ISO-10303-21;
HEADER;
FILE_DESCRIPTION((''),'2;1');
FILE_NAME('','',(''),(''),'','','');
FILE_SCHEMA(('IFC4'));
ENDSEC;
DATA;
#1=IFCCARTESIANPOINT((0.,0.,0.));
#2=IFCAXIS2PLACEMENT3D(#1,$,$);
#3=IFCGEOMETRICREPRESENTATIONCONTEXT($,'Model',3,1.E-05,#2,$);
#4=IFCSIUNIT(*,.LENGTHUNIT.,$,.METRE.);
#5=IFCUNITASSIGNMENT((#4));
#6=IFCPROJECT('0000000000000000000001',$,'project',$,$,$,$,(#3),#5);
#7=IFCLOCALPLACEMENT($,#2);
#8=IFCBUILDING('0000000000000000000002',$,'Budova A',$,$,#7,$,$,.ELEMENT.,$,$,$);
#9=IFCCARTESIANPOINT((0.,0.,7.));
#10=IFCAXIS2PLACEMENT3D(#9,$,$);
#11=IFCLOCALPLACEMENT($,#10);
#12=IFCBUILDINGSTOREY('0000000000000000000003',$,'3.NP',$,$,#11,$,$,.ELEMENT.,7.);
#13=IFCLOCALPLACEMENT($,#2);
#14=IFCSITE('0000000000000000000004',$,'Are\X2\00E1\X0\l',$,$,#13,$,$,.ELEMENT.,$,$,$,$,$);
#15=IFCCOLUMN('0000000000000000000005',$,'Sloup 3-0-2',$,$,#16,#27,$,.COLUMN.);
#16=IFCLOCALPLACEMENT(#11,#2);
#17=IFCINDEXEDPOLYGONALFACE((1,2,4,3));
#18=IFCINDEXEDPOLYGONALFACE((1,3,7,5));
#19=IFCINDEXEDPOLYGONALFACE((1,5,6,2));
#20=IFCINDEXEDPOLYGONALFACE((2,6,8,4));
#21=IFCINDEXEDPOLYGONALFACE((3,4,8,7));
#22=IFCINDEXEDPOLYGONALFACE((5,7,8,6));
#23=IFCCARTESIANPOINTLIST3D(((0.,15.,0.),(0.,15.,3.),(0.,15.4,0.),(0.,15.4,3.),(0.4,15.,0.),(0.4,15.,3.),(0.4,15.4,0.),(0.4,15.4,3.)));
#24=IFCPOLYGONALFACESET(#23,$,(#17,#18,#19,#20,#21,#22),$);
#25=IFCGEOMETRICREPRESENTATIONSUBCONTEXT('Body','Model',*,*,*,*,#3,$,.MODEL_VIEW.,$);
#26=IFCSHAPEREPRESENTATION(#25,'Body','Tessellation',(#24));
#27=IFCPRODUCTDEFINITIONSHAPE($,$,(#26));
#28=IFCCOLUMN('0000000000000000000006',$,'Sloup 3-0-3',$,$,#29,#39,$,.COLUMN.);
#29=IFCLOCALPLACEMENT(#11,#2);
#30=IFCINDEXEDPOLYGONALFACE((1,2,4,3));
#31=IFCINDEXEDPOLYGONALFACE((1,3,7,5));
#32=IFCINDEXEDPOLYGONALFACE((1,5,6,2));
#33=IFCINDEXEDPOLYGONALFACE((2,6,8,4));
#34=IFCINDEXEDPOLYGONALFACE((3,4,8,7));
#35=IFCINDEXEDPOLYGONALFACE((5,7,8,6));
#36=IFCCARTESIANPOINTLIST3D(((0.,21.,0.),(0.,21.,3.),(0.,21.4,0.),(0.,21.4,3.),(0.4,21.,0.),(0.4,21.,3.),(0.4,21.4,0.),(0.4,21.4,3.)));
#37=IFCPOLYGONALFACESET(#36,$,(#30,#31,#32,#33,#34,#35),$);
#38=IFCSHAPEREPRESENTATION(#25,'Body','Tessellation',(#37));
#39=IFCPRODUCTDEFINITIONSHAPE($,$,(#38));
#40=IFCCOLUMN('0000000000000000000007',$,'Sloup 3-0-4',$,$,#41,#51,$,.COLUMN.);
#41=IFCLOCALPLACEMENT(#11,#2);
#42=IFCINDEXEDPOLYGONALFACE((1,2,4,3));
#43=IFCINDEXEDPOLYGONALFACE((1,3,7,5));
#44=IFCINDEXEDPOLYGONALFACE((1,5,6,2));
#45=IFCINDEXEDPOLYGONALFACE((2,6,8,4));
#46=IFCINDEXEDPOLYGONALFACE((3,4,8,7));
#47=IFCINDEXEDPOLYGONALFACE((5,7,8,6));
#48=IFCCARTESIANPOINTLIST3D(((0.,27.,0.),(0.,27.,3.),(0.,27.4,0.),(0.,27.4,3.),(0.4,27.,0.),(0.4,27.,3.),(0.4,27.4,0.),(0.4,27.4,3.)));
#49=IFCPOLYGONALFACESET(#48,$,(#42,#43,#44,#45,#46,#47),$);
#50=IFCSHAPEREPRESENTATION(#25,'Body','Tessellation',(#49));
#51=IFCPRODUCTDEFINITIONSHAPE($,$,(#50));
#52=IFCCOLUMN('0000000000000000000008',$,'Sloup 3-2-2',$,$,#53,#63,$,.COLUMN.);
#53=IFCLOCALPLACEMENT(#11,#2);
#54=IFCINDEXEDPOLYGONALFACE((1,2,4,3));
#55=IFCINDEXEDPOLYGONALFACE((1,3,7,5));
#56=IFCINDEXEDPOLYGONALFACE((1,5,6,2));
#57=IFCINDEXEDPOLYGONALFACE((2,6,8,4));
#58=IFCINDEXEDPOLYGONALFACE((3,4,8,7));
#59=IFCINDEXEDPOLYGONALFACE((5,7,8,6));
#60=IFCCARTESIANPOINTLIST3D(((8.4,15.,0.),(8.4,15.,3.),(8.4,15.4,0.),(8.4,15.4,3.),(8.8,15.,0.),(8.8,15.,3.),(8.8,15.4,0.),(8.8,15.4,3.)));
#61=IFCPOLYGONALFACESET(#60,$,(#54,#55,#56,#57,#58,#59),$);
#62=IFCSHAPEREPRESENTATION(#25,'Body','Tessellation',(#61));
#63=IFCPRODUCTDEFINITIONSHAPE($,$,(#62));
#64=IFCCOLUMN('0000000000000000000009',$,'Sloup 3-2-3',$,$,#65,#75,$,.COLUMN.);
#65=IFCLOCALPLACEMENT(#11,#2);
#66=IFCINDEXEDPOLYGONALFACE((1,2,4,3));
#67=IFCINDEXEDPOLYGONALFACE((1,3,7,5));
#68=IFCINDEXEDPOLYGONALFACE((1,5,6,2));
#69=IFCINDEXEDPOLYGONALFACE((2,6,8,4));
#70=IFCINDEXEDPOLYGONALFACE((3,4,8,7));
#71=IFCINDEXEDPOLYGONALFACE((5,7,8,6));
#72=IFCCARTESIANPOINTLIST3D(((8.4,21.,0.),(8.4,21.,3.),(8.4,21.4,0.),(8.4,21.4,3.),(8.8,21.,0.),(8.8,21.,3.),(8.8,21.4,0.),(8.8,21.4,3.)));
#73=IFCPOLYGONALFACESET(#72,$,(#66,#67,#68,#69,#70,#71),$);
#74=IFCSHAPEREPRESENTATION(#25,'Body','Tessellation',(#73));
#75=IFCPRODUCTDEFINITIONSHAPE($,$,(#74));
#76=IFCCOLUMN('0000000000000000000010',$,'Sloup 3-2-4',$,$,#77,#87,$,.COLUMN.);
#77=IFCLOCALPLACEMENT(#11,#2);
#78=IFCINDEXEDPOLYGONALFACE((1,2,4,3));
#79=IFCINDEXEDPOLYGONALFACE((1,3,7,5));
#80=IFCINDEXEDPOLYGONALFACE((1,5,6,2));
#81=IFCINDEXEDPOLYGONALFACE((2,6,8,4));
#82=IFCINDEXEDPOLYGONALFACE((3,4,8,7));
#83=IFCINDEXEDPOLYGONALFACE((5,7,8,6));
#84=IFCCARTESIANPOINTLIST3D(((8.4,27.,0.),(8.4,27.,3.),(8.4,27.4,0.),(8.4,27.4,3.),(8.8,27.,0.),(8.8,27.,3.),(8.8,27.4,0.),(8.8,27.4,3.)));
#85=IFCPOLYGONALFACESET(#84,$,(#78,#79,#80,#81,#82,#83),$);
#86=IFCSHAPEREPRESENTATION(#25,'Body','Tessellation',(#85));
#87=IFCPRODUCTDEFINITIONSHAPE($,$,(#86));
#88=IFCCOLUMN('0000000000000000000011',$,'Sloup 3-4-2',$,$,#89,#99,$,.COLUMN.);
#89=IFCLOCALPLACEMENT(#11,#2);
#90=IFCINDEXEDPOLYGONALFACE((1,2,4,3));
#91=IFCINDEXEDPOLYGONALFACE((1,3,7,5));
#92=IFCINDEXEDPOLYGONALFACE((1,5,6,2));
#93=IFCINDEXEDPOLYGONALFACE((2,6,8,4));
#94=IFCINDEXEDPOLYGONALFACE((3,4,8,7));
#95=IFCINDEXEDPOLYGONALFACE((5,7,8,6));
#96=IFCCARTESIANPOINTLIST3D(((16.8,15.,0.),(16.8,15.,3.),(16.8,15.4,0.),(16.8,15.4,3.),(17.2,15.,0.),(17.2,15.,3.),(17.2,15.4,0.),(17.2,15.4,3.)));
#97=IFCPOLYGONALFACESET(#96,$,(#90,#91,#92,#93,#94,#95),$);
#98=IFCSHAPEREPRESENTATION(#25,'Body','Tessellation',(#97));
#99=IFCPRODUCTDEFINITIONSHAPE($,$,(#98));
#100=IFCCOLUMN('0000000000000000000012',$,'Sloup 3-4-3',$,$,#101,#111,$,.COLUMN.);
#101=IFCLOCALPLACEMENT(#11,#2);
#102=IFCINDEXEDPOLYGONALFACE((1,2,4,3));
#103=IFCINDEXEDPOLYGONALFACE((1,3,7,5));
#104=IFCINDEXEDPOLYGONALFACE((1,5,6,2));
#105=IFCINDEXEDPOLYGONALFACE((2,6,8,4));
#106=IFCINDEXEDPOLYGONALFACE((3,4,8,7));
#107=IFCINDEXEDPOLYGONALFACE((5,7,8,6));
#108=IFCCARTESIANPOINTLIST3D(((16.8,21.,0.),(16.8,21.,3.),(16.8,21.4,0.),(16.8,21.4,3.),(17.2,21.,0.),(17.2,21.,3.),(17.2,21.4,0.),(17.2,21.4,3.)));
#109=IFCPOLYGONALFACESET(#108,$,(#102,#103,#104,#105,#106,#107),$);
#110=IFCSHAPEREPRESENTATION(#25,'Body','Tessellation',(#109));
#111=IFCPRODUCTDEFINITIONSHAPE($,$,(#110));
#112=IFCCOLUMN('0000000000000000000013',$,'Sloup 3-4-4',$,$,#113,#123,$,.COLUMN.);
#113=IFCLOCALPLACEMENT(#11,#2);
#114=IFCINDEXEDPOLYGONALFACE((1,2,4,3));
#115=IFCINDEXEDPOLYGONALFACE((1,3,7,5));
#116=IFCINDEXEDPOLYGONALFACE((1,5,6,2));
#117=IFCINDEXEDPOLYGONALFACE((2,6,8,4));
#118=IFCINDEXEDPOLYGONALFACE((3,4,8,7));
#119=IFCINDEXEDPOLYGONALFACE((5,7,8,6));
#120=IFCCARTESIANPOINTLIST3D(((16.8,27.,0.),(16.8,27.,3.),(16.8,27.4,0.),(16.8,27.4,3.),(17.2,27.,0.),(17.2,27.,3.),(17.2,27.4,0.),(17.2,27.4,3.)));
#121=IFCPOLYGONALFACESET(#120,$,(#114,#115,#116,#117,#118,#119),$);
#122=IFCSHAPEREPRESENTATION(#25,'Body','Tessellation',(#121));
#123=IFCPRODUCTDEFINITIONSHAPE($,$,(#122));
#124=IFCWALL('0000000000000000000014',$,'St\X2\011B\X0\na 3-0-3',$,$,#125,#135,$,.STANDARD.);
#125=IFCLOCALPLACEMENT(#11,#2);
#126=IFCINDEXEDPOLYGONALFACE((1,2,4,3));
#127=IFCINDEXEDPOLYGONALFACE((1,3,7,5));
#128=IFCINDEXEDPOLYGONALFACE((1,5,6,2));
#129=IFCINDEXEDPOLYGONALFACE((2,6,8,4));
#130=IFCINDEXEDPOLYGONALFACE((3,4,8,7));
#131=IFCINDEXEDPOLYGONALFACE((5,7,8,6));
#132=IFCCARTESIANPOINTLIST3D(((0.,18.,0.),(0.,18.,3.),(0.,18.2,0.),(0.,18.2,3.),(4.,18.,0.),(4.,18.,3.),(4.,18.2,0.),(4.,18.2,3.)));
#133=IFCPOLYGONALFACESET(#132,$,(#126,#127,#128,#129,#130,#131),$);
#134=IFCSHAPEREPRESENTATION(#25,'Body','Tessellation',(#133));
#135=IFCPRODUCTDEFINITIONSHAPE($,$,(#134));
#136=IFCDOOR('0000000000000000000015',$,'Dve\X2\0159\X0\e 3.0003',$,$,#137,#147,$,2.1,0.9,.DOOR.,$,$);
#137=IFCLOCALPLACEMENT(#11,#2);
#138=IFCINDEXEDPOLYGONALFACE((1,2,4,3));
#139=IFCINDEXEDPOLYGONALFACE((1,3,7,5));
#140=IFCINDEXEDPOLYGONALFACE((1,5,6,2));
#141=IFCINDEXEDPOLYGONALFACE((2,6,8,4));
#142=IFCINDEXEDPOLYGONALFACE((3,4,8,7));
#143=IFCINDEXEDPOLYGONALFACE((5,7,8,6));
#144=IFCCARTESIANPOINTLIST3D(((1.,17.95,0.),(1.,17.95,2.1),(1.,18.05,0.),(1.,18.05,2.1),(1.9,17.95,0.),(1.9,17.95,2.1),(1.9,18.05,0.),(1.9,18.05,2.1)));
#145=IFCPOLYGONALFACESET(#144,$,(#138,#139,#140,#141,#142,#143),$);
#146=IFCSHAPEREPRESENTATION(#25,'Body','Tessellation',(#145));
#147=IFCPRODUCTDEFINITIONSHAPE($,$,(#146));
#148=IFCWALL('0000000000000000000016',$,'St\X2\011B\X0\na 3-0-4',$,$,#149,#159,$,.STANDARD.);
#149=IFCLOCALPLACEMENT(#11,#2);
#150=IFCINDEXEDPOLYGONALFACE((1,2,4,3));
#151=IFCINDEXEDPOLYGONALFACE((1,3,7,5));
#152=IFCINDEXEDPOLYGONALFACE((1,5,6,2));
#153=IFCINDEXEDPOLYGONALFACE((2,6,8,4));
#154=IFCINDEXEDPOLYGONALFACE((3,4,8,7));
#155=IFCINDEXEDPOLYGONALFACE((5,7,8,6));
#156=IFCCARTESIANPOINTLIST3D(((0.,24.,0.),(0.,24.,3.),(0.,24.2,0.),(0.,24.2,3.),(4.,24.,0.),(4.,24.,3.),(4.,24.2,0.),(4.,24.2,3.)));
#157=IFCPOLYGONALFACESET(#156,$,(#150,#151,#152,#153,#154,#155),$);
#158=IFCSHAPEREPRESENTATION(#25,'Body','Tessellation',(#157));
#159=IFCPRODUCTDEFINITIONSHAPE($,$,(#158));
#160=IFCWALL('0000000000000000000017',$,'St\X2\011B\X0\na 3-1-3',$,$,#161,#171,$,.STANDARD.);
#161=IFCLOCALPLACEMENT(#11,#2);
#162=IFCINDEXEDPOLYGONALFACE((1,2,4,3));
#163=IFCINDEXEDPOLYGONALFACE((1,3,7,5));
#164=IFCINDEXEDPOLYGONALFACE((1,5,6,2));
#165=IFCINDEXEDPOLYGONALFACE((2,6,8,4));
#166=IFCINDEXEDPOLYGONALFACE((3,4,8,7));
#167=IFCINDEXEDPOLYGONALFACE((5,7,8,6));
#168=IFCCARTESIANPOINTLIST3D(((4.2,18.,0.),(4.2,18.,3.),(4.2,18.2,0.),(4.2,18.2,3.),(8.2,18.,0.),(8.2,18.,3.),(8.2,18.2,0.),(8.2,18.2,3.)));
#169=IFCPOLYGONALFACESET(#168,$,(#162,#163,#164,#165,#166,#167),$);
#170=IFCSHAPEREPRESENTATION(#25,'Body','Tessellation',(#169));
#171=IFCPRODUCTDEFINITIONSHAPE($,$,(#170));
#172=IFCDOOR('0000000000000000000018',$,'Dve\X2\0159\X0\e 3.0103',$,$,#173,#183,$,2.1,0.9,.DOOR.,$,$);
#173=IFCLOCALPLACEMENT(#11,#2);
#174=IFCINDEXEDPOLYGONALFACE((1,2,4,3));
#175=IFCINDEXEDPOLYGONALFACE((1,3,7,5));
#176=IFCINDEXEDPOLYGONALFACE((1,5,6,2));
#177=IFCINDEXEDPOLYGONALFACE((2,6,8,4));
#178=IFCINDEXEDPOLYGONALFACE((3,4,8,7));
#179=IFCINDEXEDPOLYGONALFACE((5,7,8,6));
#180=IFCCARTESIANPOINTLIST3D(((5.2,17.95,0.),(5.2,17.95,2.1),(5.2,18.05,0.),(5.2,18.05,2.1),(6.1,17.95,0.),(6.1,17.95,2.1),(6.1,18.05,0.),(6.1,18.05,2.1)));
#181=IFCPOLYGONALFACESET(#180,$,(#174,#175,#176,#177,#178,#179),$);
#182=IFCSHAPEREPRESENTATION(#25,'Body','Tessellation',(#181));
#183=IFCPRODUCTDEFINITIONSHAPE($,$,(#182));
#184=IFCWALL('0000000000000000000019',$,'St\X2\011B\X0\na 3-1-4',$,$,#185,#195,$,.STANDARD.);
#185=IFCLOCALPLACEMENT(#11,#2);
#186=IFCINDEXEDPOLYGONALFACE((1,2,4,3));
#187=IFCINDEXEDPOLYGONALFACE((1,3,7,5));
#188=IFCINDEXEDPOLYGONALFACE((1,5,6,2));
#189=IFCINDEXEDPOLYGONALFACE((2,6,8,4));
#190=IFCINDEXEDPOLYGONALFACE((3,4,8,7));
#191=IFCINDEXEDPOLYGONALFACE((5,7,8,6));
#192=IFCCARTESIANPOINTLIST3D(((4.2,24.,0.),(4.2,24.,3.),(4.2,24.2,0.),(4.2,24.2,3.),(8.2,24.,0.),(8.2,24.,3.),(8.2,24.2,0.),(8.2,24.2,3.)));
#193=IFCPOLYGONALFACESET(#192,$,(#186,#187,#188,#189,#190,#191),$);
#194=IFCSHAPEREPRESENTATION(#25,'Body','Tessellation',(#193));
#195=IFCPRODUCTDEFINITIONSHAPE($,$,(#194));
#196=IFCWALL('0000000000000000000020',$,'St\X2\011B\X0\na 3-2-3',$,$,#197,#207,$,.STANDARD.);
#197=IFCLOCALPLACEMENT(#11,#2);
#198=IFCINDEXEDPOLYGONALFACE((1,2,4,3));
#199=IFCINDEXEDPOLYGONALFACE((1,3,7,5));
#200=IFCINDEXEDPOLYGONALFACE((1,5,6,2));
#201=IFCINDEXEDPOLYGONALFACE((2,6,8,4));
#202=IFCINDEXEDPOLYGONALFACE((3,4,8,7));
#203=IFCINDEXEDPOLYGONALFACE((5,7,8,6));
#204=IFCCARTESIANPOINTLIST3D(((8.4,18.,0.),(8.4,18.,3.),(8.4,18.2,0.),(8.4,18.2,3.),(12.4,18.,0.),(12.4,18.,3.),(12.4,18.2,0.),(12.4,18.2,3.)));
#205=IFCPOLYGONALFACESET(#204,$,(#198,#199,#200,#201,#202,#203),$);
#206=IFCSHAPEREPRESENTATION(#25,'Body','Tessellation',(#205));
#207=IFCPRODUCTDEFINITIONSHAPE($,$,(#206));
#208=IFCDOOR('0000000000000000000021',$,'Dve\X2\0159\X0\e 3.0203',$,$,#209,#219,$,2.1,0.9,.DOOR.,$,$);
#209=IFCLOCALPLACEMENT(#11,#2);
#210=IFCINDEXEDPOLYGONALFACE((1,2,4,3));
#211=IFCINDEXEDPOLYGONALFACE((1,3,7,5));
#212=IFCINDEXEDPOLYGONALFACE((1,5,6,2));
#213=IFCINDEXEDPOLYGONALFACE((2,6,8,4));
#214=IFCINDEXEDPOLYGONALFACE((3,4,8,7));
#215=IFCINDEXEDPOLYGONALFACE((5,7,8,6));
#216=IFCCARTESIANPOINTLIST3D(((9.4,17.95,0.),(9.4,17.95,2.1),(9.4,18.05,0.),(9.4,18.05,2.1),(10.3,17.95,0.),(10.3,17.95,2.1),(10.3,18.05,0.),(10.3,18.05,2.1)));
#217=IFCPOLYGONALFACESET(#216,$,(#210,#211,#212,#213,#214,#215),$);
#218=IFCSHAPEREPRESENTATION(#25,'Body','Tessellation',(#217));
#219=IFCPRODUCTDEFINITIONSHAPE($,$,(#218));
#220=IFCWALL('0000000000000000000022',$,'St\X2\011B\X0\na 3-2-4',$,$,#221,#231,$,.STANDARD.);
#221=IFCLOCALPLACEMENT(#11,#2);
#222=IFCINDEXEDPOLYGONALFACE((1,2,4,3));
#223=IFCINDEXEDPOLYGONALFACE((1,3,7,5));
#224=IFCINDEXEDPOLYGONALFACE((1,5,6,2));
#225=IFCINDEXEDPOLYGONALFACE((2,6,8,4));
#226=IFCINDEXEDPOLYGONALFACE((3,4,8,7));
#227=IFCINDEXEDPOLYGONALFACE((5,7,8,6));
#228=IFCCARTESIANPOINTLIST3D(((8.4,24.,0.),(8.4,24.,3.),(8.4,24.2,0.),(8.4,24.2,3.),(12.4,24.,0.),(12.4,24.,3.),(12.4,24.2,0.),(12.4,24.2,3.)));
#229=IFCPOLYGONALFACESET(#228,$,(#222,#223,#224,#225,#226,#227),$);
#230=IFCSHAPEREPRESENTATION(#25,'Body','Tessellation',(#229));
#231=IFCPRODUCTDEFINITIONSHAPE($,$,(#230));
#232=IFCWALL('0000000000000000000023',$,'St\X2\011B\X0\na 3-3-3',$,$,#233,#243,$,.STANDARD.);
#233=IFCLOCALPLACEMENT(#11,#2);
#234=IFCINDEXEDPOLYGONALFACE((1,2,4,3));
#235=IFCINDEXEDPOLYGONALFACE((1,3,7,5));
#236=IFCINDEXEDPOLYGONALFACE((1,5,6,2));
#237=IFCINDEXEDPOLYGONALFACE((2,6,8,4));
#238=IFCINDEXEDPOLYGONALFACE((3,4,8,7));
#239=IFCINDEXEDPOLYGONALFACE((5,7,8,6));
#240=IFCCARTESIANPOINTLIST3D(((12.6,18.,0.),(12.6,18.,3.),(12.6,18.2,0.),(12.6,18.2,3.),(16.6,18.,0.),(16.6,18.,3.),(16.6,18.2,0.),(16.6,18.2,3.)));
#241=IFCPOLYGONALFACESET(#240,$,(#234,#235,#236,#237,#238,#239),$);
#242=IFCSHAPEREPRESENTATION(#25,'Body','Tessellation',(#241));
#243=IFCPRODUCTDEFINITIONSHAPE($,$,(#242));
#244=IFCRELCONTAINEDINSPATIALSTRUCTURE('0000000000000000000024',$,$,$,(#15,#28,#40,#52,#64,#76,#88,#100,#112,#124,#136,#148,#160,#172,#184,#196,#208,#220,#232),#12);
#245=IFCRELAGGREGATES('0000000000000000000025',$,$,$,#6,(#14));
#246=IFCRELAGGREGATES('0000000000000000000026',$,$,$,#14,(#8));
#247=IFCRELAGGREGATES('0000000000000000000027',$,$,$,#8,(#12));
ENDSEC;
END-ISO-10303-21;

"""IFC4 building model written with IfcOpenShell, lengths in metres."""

from ifc_helpers import new_model, si_unit, frame, frame_2d, origin, place, context, subcontext, project, spatial, rectangle, extrude, element, save


model = new_model("IFC4")

# Units and contexts
model_context = context("Model", 3, precision=1e-05, world=origin())
body_context = subcontext(model_context, "Body", "Model", "MODEL_VIEW")
ifc_project = project(units=[si_unit("LENGTHUNIT", "METRE")], contexts=[model_context])

# Site, building, storey
site_placement = place(None, origin())
site = spatial("IfcSite", under=ifc_project, at=site_placement, Name="Areál", CompositionType="ELEMENT")
building_placement = place(None, origin())
building = spatial("IfcBuilding", under=site, at=building_placement, Name="Budova A", CompositionType="ELEMENT")
storey_placement = place(None, frame((0.0, 0.0, 7.0)))
storey = spatial("IfcBuildingStorey", under=building, at=storey_placement, Name="3.NP", CompositionType="ELEMENT", Elevation=7.0)

# Columns
for number, where, name in (
    (1, (0.0, 15.0, 0.0), "Sloup 3-0-2"),
    (2, (0.0, 21.0, 0.0), "Sloup 3-0-3"),
    (3, (0.0, 27.0, 0.0), "Sloup 3-0-4"),
    (4, (8.4, 15.0, 0.0), "Sloup 3-2-2"),
    (5, (8.4, 21.0, 0.0), "Sloup 3-2-3"),
    (6, (8.4, 27.0, 0.0), "Sloup 3-2-4"),
    (7, (16.8, 15.0, 0.0), "Sloup 3-4-2"),
    (8, (16.8, 21.0, 0.0), "Sloup 3-4-3"),
    (9, (16.8, 27.0, 0.0), "Sloup 3-4-4"),
):
    element("IfcColumn", number, at=place(storey_placement, frame(where)), inside=storey, Name=name, PredefinedType="COLUMN", context=body_context, shape_type="SweptSolid", body=[
        extrude(rectangle(XDim=0.4, YDim=0.4, at=frame_2d((0.2, 0.2))), origin(), (0.0, 0.0, 1.0), 3.0),
    ])

# Wall
wall_1_placement = place(storey_placement, frame((0.0, 18.0, 0.0)))
element("IfcWall", 10, at=wall_1_placement, inside=storey, Name="Stěna 3-0-3", PredefinedType="STANDARD", context=body_context, shape_type="SweptSolid", body=[
    extrude(rectangle(XDim=4.0, YDim=0.2, at=frame_2d((2.0, 0.1))), origin(), (0.0, 0.0, 1.0), 3.0),
])

# Door
door_1_placement = place(storey_placement, frame((1.0, 17.95, 0.0)))
element("IfcDoor", 11, at=door_1_placement, inside=storey, Name="Dveře 3.0003", OverallHeight=2.1, OverallWidth=0.9, PredefinedType="DOOR", context=body_context, shape_type="SweptSolid", body=[
    extrude(rectangle(XDim=0.9, YDim=0.1, at=frame_2d((0.45, 0.05))), origin(), (0.0, 0.0, 1.0), 2.1),
])

# Walls
for number, where, name in (
    (12, (0.0, 24.0, 0.0), "Stěna 3-0-4"),
    (13, (4.2, 18.0, 0.0), "Stěna 3-1-3"),
):
    element("IfcWall", number, at=place(storey_placement, frame(where)), inside=storey, Name=name, PredefinedType="STANDARD", context=body_context, shape_type="SweptSolid", body=[
        extrude(rectangle(XDim=4.0, YDim=0.2, at=frame_2d((2.0, 0.1))), origin(), (0.0, 0.0, 1.0), 3.0),
    ])

# Door
door_2_placement = place(storey_placement, frame((5.2, 17.95, 0.0)))
element("IfcDoor", 14, at=door_2_placement, inside=storey, Name="Dveře 3.0103", OverallHeight=2.1, OverallWidth=0.9, PredefinedType="DOOR", context=body_context, shape_type="SweptSolid", body=[
    extrude(rectangle(XDim=0.9, YDim=0.1, at=frame_2d((0.45, 0.05))), origin(), (0.0, 0.0, 1.0), 2.1),
])

# Walls
for number, where, name in (
    (15, (4.2, 24.0, 0.0), "Stěna 3-1-4"),
    (16, (8.4, 18.0, 0.0), "Stěna 3-2-3"),
):
    element("IfcWall", number, at=place(storey_placement, frame(where)), inside=storey, Name=name, PredefinedType="STANDARD", context=body_context, shape_type="SweptSolid", body=[
        extrude(rectangle(XDim=4.0, YDim=0.2, at=frame_2d((2.0, 0.1))), origin(), (0.0, 0.0, 1.0), 3.0),
    ])

# Door
door_3_placement = place(storey_placement, frame((9.4, 17.95, 0.0)))
element("IfcDoor", 17, at=door_3_placement, inside=storey, Name="Dveře 3.0203", OverallHeight=2.1, OverallWidth=0.9, PredefinedType="DOOR", context=body_context, shape_type="SweptSolid", body=[
    extrude(rectangle(XDim=0.9, YDim=0.1, at=frame_2d((0.45, 0.05))), origin(), (0.0, 0.0, 1.0), 2.1),
])

# Walls
for number, where, name in (
    (18, (8.4, 24.0, 0.0), "Stěna 3-2-4"),
    (19, (12.6, 18.0, 0.0), "Stěna 3-3-3"),
):
    element("IfcWall", number, at=place(storey_placement, frame(where)), inside=storey, Name=name, PredefinedType="STANDARD", context=body_context, shape_type="SweptSolid", body=[
        extrude(rectangle(XDim=4.0, YDim=0.2, at=frame_2d((2.0, 0.1))), origin(), (0.0, 0.0, 1.0), 3.0),
    ])

save(model, "model.ifc")
